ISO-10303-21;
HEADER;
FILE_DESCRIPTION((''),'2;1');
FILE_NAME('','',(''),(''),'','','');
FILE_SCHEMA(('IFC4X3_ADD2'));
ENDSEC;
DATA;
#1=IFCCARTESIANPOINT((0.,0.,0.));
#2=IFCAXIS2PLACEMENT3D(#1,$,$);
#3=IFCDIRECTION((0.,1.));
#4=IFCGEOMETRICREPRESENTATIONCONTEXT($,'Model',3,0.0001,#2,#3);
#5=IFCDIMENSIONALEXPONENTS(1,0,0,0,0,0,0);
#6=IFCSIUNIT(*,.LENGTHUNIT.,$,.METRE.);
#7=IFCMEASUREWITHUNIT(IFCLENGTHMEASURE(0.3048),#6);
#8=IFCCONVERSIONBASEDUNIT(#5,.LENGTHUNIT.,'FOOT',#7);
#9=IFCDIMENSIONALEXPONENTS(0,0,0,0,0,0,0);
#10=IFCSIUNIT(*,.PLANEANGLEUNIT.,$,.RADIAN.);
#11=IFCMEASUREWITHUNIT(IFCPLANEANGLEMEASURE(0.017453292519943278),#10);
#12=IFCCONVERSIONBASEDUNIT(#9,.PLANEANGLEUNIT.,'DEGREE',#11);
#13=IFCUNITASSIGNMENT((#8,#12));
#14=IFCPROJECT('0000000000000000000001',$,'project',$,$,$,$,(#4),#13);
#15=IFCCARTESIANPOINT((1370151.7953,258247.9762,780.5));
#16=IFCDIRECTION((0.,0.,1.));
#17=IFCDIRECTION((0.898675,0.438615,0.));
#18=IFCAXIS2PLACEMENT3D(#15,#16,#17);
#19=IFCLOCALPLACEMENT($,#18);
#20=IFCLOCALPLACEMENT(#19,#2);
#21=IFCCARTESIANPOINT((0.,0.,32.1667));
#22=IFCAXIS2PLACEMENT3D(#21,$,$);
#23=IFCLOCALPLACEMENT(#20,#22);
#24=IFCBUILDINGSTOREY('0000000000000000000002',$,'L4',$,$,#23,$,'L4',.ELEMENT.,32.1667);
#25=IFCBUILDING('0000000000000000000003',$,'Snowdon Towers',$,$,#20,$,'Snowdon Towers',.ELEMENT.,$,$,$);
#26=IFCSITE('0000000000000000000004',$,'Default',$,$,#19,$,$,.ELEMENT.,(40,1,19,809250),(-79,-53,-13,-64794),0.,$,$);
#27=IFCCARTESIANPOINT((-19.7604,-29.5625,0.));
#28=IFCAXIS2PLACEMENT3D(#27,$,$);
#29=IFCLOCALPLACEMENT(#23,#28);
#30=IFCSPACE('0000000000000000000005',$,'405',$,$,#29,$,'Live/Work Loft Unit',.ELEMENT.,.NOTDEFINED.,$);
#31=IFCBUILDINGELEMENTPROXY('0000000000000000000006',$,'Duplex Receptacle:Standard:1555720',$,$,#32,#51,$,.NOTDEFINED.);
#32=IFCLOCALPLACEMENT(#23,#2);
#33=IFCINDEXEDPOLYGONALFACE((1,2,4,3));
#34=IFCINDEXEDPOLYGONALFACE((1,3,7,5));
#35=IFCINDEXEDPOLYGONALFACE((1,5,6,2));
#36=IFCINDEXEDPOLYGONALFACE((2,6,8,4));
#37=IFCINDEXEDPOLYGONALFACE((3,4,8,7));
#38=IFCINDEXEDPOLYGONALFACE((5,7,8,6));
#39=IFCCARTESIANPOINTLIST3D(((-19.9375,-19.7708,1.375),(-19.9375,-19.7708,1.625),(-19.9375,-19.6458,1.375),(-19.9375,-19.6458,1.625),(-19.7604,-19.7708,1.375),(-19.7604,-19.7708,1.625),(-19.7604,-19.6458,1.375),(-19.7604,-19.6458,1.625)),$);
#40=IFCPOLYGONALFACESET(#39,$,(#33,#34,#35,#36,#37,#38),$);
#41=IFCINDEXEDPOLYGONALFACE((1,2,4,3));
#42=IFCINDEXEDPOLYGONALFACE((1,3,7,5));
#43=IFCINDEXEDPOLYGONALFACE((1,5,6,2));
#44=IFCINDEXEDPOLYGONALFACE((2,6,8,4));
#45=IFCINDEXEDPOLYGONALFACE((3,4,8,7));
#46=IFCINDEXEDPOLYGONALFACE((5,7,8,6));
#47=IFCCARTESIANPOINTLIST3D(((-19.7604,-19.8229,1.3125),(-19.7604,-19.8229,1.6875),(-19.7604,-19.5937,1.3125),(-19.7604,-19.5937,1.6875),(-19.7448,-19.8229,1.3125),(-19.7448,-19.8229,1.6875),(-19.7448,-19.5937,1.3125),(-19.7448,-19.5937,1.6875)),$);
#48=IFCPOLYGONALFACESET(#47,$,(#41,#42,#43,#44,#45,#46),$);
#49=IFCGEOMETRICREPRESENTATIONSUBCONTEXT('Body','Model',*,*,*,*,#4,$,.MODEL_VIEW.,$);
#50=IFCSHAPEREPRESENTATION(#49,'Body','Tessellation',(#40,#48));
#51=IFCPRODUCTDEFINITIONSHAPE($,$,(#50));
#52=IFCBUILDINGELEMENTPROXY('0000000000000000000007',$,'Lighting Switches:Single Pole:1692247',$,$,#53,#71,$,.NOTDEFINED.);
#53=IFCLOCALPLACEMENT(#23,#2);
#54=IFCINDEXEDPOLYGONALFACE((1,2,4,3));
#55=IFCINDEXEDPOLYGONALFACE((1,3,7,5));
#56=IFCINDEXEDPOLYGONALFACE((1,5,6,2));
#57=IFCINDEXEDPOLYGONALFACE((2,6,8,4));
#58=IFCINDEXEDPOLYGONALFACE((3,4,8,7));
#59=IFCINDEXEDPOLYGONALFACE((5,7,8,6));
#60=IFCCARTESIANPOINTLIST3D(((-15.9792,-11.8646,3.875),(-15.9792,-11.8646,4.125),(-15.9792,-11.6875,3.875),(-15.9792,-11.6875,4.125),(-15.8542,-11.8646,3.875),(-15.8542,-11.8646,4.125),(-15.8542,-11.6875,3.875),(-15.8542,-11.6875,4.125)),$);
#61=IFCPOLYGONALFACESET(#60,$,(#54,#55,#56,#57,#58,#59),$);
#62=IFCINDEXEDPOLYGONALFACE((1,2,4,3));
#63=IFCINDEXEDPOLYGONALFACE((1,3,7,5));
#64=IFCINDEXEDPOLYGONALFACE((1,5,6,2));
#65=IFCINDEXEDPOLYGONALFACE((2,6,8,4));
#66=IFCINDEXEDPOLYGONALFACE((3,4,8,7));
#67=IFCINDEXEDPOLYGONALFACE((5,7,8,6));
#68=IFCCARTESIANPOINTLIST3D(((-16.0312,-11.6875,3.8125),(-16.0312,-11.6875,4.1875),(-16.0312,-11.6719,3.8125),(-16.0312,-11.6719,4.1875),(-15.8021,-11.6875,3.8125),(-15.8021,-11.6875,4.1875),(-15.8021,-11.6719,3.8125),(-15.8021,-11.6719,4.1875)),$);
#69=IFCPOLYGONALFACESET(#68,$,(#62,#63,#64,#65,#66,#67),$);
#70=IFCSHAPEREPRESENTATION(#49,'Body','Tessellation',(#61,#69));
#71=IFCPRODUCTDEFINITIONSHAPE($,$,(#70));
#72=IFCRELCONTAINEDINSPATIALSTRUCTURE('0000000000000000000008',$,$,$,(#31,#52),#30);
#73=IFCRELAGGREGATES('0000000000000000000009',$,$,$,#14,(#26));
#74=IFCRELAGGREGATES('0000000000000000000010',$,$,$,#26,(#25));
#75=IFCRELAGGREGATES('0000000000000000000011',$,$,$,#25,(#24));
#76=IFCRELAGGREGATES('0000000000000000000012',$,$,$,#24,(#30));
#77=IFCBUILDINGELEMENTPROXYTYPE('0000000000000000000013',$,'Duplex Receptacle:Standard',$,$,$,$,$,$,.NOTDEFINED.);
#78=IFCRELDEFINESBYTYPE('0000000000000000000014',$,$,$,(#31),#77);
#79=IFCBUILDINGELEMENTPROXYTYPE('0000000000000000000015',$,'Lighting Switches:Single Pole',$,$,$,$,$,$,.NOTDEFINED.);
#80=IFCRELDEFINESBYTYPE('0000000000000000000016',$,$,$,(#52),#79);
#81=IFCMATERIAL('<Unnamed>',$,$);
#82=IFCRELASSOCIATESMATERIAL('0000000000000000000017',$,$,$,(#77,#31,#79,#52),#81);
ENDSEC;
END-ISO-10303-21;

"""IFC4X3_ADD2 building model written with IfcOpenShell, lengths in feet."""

from ifc_helpers import new_model, entity, si_unit, converted_unit, direction, frame, frame_2d, origin, origin_2d_with_axis, place, context, subcontext, project, spatial, rectangle, extrude, source, transform, mapped, material, type_object, type_shapes, element, save


model = new_model("IFC4X3_ADD2")

# Units and contexts
model_context = context("Model", 3, precision=0.0001, world=origin(), true_north=direction((0.0, 1.0)))
body_context = subcontext(model_context, "Body", "Model", "MODEL_VIEW")
ifc_project = project(units=[converted_unit("LENGTHUNIT", "FOOT", entity("IfcLengthMeasure", 0.3048), si_unit("LENGTHUNIT", "METRE"), dimensions=[1, 0, 0, 0, 0, 0, 0]), converted_unit("PLANEANGLEUNIT", "DEGREE", entity("IfcPlaneAngleMeasure", 0.017453292519943278), si_unit("PLANEANGLEUNIT", "RADIAN"), dimensions=[0, 0, 0, 0, 0, 0, 0])], contexts=[model_context])

# Site, building, storey, space
site_placement = place(None, frame((1370151.7953, 258247.9762, 780.5), z_axis=(0.0, 0.0, 1.0), x_axis=(0.898675, 0.438615, 0.0)))
site = spatial("IfcSite", under=ifc_project, at=site_placement, Name="Default", CompositionType="ELEMENT", RefLatitude=(40, 1, 19, 809250), RefLongitude=(-79, -53, -13, -64794), RefElevation=0.0)
building_placement = place(site_placement, origin())
building = spatial("IfcBuilding", under=site, at=building_placement, Name="Snowdon Towers", LongName="Snowdon Towers", CompositionType="ELEMENT")
storey_placement = place(building_placement, frame((0.0, 0.0, 32.1667)))
storey = spatial("IfcBuildingStorey", under=building, at=storey_placement, Name="L4", LongName="L4", CompositionType="ELEMENT", Elevation=32.1667)
space_1_placement = place(storey_placement, frame((-19.7604, -29.5625, 0.0)))
space_1 = spatial("IfcSpace", under=storey, at=space_1_placement, Name="405", LongName="Live/Work Loft Unit", CompositionType="ELEMENT", PredefinedType="NOTDEFINED")

# Shared definitions
ifc_material_1 = material(Name="<Unnamed>")

# Building element proxies
building_element_proxy_type_1 = type_object("IfcBuildingElementProxyType", Name="Duplex Receptacle:Standard", PredefinedType="NOTDEFINED", material=ifc_material_1)
shared_shape_1 = source(origin(), body_context, "Body", "SweptSolid", [
    extrude(rectangle(XDim=0.125, YDim=0.25, at=origin_2d_with_axis()), frame((0.0, 0.0, -0.1771), z_axis=(0.0, 0.0, 1.0), x_axis=(-1.0, 0.0, 0.0)), (0.0, 0.0, 1.0), 0.1771),
    extrude(rectangle(XDim=0.2292, YDim=0.375, at=frame_2d((0.0, 0.0), x_axis=(1.0, 0.0))), frame((0.0, 0.0, 0.0), z_axis=(0.0, 0.0, 1.0), x_axis=(-1.0, 0.0, 0.0)), (0.0, 0.0, 1.0), 0.0156),
])
type_shapes(building_element_proxy_type_1, [shared_shape_1])
for number, where, z_axis, x_axis, name in (
    (1, (0.0, 9.8542, 1.5), (1.0, 0.0, 0.0), (0.0, 1.0, 0.0), "Duplex Receptacle:Standard:1555720"),
):
    element("IfcBuildingElementProxy", number, at=place(space_1_placement, frame(where, z_axis=z_axis, x_axis=x_axis)), inside=space_1, type_object=building_element_proxy_type_1, material=ifc_material_1, Name=name, PredefinedType="NOTDEFINED", context=body_context, shape_type="MappedRepresentation", body=[
        mapped(shared_shape_1, transform((0.0, 0.0, 0.0), scale=1.0)),
    ])
building_element_proxy_type_2 = type_object("IfcBuildingElementProxyType", Name="Lighting Switches:Single Pole", PredefinedType="NOTDEFINED", material=ifc_material_1)
shared_shape_2 = source(origin(), body_context, "Body", "SweptSolid", [
    extrude(rectangle(XDim=0.125, YDim=0.25, at=origin_2d_with_axis()), frame((0.0, 0.0, -0.1771), z_axis=(0.0, 0.0, 1.0), x_axis=(-1.0, 0.0, 0.0)), (0.0, 0.0, 1.0), 0.1771),
    extrude(rectangle(XDim=0.2292, YDim=0.375, at=frame_2d((0.0, 0.0), x_axis=(1.0, 0.0))), frame((0.0, 0.0, 0.0), z_axis=(0.0, 0.0, 1.0), x_axis=(-1.0, 0.0, 0.0)), (0.0, 0.0, 1.0), 0.0156),
])
type_shapes(building_element_proxy_type_2, [shared_shape_2])
for number, where, z_axis, x_axis, name in (
    (2, (3.8438, 17.875, 4.0), (0.0, 1.0, 0.0), (-1.0, 0.0, 0.0), "Lighting Switches:Single Pole:1692247"),
):
    element("IfcBuildingElementProxy", number, at=place(space_1_placement, frame(where, z_axis=z_axis, x_axis=x_axis)), inside=space_1, type_object=building_element_proxy_type_2, material=ifc_material_1, Name=name, PredefinedType="NOTDEFINED", context=body_context, shape_type="MappedRepresentation", body=[
        mapped(shared_shape_2, transform((0.0, 0.0, 0.0), scale=1.0)),
    ])

save(model, "model.ifc")
